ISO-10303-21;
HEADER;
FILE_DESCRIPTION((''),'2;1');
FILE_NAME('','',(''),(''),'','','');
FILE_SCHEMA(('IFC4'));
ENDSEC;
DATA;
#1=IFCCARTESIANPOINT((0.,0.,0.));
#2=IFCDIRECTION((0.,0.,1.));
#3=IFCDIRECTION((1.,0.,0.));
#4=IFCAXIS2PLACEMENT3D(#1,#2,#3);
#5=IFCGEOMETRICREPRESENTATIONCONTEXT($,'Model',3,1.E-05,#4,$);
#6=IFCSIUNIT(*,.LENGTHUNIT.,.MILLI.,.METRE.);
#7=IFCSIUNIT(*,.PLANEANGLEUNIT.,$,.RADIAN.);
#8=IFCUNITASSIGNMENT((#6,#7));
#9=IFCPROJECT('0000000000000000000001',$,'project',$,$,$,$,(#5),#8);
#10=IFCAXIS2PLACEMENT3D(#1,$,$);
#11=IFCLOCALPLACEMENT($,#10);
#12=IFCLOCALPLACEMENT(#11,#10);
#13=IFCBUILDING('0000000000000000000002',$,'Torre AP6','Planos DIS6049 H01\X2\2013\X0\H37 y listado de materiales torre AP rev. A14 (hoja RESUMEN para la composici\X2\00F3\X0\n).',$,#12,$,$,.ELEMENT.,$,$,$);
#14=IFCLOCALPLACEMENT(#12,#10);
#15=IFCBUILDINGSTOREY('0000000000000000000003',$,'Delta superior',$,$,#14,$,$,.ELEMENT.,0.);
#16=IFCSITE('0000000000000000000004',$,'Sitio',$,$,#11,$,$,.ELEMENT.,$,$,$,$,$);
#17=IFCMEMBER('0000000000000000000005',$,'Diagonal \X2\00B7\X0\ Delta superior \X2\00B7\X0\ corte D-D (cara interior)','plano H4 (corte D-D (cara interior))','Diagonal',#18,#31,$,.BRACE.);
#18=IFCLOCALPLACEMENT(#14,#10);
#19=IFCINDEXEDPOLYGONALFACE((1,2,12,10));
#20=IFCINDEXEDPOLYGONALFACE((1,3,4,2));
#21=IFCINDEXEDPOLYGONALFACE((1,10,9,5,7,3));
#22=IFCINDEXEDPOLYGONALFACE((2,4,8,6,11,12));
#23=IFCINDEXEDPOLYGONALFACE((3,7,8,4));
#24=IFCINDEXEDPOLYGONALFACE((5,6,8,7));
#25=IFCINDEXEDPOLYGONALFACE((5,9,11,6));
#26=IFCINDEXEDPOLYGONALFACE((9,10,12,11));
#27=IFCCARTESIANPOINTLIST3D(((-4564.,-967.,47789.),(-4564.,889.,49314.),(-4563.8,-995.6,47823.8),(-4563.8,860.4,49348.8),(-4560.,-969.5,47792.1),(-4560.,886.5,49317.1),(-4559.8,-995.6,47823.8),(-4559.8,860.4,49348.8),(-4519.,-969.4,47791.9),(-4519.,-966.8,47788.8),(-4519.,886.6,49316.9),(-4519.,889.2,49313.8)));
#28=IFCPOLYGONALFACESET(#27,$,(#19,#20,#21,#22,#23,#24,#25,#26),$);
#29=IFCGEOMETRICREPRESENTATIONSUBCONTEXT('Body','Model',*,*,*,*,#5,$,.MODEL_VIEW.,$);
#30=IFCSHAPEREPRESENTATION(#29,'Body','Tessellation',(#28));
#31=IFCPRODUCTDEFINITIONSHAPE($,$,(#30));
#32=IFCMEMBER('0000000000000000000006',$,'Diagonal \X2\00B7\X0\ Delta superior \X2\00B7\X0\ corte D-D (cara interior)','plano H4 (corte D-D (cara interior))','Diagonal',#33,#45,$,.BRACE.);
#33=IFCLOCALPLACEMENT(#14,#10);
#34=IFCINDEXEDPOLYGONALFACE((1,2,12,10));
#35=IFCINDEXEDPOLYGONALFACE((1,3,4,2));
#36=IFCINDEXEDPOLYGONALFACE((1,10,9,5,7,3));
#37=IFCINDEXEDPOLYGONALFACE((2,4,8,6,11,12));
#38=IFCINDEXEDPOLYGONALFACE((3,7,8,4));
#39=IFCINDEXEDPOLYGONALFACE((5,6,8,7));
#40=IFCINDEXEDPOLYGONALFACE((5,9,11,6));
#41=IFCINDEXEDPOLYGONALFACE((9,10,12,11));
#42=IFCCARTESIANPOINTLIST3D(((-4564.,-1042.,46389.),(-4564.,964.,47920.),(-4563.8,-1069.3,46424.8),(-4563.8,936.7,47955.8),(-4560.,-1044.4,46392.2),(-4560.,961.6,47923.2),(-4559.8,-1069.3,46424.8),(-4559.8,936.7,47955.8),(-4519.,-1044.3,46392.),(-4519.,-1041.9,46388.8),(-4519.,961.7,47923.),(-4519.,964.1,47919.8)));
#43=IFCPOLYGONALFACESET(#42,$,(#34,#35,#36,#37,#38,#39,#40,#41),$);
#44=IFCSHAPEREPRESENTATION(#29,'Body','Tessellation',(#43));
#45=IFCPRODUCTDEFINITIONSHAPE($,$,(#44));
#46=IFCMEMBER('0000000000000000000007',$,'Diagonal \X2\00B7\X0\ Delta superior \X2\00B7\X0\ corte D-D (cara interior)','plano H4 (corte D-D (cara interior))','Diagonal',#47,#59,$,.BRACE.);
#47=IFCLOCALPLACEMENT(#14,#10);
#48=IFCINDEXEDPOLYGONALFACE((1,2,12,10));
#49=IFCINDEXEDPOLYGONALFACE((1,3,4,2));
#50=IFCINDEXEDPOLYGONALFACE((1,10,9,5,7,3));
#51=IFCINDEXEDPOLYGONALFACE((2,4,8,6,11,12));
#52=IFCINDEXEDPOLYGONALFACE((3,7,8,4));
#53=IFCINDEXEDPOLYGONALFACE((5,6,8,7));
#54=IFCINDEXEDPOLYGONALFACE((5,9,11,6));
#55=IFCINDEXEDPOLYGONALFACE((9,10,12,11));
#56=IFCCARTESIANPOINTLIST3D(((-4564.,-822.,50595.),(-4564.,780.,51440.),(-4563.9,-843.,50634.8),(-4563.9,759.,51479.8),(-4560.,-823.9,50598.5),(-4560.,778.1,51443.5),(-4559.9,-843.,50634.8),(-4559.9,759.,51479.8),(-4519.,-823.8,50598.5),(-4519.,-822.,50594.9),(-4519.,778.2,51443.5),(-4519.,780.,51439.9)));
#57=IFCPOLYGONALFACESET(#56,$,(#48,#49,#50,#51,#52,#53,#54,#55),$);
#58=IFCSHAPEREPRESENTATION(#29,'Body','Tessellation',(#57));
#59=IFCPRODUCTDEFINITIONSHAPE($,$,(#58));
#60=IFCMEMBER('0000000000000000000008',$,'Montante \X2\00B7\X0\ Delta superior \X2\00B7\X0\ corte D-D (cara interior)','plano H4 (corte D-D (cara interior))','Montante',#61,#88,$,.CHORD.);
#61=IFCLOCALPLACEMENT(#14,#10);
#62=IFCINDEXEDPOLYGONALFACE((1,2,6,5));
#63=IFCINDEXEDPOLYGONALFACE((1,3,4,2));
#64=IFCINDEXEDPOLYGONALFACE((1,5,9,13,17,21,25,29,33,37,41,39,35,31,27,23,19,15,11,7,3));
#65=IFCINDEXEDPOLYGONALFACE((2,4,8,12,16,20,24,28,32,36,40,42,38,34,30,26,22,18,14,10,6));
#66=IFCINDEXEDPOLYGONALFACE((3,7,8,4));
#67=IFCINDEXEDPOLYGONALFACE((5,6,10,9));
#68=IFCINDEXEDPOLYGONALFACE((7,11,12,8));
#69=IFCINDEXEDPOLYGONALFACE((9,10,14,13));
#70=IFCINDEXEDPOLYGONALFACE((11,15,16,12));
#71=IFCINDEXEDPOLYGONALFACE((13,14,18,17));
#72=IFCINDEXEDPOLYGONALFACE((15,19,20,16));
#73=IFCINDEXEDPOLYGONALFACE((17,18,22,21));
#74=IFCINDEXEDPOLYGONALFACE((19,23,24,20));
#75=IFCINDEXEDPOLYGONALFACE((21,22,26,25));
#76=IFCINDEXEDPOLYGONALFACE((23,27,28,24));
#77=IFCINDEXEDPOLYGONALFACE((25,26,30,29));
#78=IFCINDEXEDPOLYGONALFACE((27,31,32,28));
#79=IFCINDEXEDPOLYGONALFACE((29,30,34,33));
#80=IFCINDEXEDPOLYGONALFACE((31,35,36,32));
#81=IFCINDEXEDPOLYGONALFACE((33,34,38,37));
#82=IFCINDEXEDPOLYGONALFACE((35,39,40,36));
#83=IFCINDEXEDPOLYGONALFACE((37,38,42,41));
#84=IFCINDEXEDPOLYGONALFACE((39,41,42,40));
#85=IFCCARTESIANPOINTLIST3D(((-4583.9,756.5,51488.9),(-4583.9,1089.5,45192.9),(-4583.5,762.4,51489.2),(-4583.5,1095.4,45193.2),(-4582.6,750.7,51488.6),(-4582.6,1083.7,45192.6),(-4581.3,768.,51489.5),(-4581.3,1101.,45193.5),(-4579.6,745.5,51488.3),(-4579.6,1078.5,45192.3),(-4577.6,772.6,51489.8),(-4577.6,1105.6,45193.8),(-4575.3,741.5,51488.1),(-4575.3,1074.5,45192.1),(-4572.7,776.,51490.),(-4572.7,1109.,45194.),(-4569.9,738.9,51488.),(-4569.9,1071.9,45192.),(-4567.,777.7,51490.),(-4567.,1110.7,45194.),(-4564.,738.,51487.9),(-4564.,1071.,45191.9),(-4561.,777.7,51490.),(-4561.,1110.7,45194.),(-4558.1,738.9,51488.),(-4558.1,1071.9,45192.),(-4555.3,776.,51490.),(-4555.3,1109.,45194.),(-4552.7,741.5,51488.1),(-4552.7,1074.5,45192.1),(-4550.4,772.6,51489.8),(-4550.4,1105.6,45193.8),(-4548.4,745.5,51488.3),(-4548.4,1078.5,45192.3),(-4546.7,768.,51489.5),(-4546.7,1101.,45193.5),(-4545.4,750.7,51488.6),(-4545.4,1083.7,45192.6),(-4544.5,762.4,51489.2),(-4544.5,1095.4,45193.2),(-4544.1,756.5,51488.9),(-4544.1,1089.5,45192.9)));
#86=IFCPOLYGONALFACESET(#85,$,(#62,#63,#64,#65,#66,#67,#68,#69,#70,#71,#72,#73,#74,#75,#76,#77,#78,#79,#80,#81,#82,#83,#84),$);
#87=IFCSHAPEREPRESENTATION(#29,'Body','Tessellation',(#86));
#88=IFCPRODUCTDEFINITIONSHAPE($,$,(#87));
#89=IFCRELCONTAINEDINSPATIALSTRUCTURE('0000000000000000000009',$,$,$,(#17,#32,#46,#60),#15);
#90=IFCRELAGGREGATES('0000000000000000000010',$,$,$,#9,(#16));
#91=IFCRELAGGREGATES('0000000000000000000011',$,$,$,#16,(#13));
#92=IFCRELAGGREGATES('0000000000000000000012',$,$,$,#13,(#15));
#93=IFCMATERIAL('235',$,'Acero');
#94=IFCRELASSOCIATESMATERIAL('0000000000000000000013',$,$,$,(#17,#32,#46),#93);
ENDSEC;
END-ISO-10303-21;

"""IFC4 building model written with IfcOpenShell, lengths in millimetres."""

from ifc_helpers import new_model, si_unit, frame, frame_2d, origin, origin_with_axes, place, context, subcontext, project, spatial, circle, l_section, extrude, material, element, save


model = new_model("IFC4")

# Units and contexts
model_context = context("Model", 3, precision=1e-05, world=origin_with_axes())
body_context = subcontext(model_context, "Body", "Model", "MODEL_VIEW")
ifc_project = project(units=[si_unit("LENGTHUNIT", "METRE", prefix="MILLI"), si_unit("PLANEANGLEUNIT", "RADIAN")], contexts=[model_context])

# Site, building, storey
site_placement = place(None, origin())
site = spatial("IfcSite", under=ifc_project, at=site_placement, Name="Sitio", CompositionType="ELEMENT")
building_placement = place(site_placement, origin())
building = spatial("IfcBuilding", under=site, at=building_placement, Name="Torre AP6", Description="Planos DIS6049 H01–H37 y listado de materiales torre AP rev. A14 (hoja RESUMEN para la composición).", CompositionType="ELEMENT")
storey_placement = place(building_placement, origin())
storey = spatial("IfcBuildingStorey", under=building, at=storey_placement, Name="Delta superior", CompositionType="ELEMENT", Elevation=0.0)

# Members
ifc_material_1 = material(Name="235", Category="Acero")
member_1_placement = place(storey_placement, frame((-4564.0, 889.0, 49314.0), z_axis=(0.0, -0.772639, -0.634846), x_axis=(0.999985, 0.003444, -0.004191)))
element("IfcMember", 1, at=member_1_placement, inside=storey, material=ifc_material_1, Name="Diagonal · Delta superior · corte D-D (cara interior)", Description="plano H4 (corte D-D (cara interior))", ObjectType="Diagonal", PredefinedType="BRACE", context=body_context, shape_type="SweptSolid", body=[
    extrude(l_section(Depth=45.0, Width=45.0, Thickness=4.0, at=frame_2d((22.5, 22.5))), None, (0.0, 0.0, 1.0), 2402.2),
])
member_2_placement = place(storey_placement, frame((-4564.0, 964.0, 47920.0), z_axis=(0.0, -0.794931, -0.6067), x_axis=(0.999987, 0.003145, -0.004121)))
element("IfcMember", 2, at=member_2_placement, inside=storey, material=ifc_material_1, Name="Diagonal · Delta superior · corte D-D (cara interior)", Description="plano H4 (corte D-D (cara interior))", ObjectType="Diagonal", PredefinedType="BRACE", context=body_context, shape_type="SweptSolid", body=[
    extrude(l_section(Depth=45.0, Width=45.0, Thickness=4.0, at=frame_2d((22.5, 22.5))), None, (0.0, 0.0, 1.0), 2523.5),
])
member_3_placement = place(storey_placement, frame((-4564.0, 780.0, 51440.0), z_axis=(0.0, -0.884499, -0.466543), x_axis=(0.999998, 0.001002, -0.001899)))
element("IfcMember", 3, at=member_3_placement, inside=storey, material=ifc_material_1, Name="Diagonal · Delta superior · corte D-D (cara interior)", Description="plano H4 (corte D-D (cara interior))", ObjectType="Diagonal", PredefinedType="BRACE", context=body_context, shape_type="SweptSolid", body=[
    extrude(l_section(Depth=45.0, Width=45.0, Thickness=4.0, at=frame_2d((22.5, 22.5))), None, (0.0, 0.0, 1.0), 1811.2),
])
member_4_placement = place(storey_placement, frame((-4564.0, 1091.0, 45193.0), z_axis=(0.0, -0.052817, 0.998604), x_axis=(0.0, -0.998604, -0.052817)))
element("IfcMember", 4, at=member_4_placement, inside=storey, Name="Montante · Delta superior · corte D-D (cara interior)", Description="plano H4 (corte D-D (cara interior))", ObjectType="Montante", PredefinedType="CHORD", context=body_context, shape_type="SweptSolid", body=[
    extrude(circle(Radius=20.0), None, (0.0, 0.0, 1.0), 6304.8),
])

save(model, "model.ifc")
